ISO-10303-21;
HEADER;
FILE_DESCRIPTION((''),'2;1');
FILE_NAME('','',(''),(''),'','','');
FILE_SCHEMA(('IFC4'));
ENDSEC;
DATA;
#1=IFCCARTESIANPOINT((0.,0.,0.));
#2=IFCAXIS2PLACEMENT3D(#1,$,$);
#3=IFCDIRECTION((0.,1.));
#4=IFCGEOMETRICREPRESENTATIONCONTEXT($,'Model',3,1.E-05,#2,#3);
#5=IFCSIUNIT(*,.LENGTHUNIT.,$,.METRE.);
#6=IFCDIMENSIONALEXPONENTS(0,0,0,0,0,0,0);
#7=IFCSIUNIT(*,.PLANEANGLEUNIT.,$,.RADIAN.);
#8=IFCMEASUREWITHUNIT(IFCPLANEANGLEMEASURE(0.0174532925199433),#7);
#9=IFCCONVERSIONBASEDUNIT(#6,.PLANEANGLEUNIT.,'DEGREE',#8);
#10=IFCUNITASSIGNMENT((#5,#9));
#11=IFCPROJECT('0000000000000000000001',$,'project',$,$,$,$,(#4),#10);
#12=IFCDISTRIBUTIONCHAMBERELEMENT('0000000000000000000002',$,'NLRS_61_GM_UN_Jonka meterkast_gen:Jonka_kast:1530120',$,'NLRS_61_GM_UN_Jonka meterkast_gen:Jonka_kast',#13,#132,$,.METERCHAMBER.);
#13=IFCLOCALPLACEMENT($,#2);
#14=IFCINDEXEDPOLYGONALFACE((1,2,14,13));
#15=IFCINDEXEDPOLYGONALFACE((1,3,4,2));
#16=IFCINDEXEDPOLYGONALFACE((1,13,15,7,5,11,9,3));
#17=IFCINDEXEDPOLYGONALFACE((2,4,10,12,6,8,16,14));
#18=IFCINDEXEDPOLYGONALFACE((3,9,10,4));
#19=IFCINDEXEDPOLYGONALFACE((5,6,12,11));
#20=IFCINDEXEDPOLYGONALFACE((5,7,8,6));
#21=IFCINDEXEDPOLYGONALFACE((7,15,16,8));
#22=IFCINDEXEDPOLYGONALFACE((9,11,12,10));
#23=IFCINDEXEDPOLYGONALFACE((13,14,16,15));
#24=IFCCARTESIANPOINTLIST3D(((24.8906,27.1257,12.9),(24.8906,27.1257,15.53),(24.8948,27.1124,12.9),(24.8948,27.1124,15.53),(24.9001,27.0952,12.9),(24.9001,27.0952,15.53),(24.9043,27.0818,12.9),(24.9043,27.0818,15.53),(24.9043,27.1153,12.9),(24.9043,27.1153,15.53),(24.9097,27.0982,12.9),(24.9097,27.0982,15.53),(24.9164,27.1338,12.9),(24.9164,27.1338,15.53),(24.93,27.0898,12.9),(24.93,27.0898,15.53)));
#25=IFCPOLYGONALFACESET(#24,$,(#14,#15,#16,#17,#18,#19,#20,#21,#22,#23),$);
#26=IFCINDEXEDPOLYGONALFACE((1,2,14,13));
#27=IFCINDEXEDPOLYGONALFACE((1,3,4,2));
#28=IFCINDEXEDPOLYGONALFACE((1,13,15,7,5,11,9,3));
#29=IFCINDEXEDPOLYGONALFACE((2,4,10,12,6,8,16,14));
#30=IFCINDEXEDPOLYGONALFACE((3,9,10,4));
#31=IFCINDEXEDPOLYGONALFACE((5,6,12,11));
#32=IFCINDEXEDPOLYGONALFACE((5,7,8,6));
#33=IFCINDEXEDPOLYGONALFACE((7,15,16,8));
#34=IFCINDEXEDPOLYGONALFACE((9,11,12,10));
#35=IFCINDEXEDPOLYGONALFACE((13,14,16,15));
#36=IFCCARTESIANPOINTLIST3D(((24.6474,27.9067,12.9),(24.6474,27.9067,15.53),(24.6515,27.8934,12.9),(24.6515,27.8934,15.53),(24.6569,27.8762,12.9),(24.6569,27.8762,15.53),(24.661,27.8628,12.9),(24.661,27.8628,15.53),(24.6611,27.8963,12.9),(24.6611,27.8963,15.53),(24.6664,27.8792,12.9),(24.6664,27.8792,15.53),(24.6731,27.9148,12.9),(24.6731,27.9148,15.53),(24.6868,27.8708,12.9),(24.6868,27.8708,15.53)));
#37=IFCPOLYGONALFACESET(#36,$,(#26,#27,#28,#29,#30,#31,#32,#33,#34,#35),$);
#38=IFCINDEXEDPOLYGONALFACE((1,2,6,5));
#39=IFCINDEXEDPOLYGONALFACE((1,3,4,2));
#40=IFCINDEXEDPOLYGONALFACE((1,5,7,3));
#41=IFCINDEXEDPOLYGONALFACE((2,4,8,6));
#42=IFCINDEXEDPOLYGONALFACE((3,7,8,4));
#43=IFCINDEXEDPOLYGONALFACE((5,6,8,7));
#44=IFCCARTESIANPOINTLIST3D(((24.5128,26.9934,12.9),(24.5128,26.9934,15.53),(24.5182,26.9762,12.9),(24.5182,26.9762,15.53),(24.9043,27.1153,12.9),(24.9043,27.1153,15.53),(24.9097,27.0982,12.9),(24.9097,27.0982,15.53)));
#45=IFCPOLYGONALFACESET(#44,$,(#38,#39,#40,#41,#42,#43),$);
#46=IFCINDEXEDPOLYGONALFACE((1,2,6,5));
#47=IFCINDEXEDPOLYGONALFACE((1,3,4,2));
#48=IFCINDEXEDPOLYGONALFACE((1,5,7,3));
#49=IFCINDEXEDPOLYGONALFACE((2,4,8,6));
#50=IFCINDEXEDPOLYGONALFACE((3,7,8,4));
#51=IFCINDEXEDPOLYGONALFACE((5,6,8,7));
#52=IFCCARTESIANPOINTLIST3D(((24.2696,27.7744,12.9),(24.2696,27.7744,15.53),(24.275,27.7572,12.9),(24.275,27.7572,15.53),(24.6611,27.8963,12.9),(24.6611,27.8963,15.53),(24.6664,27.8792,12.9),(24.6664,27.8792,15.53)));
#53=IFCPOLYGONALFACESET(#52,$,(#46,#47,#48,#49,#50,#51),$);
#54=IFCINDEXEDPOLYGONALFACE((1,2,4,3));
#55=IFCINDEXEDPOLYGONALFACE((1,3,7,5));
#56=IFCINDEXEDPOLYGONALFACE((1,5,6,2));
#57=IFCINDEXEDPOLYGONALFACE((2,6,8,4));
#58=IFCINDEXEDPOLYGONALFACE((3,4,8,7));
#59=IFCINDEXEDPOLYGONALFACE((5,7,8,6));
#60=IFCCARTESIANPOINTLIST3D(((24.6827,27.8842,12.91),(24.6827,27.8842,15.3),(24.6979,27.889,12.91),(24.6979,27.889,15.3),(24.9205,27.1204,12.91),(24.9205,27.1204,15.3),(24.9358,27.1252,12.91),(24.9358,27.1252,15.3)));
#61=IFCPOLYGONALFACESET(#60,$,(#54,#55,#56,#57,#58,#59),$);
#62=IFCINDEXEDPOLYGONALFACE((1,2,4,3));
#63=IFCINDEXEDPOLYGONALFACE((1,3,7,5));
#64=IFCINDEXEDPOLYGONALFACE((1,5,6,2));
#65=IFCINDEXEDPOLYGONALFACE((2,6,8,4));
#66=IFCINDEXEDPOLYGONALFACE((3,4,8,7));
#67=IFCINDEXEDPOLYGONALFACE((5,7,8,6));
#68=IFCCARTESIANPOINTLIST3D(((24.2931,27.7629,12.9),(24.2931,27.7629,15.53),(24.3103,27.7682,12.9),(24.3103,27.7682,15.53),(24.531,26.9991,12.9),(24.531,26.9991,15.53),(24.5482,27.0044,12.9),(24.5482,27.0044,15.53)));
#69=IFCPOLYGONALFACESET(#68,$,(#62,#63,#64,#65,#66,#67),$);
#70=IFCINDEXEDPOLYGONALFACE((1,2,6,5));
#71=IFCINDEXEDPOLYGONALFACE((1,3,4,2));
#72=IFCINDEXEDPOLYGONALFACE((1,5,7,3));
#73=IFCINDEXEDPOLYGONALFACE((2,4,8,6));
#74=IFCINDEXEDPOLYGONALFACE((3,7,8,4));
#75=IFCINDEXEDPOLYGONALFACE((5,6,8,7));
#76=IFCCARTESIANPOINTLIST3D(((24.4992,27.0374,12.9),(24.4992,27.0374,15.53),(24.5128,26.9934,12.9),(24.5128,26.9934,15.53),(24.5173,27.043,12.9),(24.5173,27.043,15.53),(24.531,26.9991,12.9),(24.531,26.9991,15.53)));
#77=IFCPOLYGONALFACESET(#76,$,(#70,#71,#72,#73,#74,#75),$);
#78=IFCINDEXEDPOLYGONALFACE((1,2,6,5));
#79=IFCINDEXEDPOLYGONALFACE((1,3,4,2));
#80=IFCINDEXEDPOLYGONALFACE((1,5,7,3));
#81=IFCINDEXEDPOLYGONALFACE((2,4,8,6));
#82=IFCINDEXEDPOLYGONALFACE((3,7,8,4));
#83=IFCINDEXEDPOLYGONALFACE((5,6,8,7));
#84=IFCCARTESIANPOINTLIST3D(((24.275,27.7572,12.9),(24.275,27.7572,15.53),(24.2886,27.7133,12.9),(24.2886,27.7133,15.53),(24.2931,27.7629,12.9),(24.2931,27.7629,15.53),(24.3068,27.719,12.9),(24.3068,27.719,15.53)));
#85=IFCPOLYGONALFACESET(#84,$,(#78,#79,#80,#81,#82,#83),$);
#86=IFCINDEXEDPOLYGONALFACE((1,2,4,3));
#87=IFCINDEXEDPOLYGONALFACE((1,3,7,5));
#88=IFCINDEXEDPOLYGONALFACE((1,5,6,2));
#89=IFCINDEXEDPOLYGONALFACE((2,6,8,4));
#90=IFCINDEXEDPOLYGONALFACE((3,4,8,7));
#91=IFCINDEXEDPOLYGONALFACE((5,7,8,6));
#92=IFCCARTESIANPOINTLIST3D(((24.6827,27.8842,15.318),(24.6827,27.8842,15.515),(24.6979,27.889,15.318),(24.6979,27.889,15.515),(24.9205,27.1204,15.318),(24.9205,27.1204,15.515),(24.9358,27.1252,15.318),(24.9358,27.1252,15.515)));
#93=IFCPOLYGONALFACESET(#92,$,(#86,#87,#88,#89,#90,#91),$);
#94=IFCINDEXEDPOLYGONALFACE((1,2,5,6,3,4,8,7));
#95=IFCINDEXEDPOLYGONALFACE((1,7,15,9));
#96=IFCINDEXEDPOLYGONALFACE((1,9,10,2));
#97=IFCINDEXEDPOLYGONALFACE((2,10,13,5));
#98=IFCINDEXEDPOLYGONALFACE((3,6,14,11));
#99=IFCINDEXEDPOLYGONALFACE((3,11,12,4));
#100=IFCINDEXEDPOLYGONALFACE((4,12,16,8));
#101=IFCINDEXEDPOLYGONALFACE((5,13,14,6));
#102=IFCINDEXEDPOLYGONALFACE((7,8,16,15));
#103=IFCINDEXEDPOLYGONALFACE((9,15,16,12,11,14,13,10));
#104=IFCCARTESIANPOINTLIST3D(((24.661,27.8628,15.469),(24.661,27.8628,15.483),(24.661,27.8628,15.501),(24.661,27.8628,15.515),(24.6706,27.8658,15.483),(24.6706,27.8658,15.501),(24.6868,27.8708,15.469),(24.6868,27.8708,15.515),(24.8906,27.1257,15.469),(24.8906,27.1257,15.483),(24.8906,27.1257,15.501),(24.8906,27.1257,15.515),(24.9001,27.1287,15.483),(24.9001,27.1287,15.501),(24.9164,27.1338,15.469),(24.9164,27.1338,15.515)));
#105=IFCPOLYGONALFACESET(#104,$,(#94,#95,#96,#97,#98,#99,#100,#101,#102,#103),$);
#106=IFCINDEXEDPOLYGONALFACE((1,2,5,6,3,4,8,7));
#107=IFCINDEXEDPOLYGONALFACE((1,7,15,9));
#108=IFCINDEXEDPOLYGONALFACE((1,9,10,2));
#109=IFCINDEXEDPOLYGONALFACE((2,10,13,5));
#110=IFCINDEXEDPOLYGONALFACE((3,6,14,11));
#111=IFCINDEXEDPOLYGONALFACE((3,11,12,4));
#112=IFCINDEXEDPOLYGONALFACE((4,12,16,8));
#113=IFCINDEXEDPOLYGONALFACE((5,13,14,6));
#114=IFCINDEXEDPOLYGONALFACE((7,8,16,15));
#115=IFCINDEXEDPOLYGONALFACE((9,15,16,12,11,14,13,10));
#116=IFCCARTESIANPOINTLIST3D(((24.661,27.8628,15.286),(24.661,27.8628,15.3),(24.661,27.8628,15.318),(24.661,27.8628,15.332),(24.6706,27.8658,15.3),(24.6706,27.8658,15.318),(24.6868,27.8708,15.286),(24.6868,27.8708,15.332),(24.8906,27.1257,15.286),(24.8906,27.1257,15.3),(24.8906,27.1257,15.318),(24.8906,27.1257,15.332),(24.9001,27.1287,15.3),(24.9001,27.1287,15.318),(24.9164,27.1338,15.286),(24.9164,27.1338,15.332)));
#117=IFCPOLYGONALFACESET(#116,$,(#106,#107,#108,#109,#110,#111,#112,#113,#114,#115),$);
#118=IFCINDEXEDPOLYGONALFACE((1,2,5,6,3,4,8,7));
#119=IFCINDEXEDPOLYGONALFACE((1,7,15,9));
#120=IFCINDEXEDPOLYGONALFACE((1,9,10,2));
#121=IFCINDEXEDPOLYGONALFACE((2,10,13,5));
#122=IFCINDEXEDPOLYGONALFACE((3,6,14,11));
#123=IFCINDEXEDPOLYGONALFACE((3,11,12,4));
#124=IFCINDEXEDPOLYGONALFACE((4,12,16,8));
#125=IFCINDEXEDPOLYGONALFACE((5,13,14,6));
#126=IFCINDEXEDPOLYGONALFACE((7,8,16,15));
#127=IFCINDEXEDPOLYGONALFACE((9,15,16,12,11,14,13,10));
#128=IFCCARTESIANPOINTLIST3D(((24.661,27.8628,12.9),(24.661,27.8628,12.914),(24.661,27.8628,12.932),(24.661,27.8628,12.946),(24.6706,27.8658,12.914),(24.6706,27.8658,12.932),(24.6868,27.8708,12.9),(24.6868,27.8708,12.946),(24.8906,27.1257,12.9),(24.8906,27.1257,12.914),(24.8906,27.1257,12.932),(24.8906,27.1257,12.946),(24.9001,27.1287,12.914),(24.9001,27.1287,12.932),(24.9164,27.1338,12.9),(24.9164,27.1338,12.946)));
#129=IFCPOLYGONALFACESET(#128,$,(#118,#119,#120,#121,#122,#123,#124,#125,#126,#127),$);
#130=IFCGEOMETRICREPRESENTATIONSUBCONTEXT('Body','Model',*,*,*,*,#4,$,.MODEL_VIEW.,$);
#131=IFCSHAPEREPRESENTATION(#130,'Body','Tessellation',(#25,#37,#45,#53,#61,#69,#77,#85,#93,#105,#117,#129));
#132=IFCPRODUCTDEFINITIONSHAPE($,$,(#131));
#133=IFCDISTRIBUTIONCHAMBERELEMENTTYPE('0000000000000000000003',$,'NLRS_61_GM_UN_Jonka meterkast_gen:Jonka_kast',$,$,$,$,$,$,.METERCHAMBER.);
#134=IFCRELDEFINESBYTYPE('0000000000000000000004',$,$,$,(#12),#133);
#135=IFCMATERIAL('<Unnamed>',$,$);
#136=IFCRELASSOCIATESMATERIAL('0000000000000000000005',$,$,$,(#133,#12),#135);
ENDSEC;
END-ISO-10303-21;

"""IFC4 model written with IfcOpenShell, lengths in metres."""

from ifc_helpers import new_model, entity, si_unit, converted_unit, direction, frame, origin, place, context, subcontext, project, indexed_curve, outline, extrude, source, transform, mapped, material, type_object, type_shapes, element, save


model = new_model("IFC4")

# Units and contexts
model_context = context("Model", 3, precision=1e-05, world=origin(), true_north=direction((0.0, 1.0)))
body_context = subcontext(model_context, "Body", "Model", "MODEL_VIEW")
ifc_project = project(units=[si_unit("LENGTHUNIT", "METRE"), converted_unit("PLANEANGLEUNIT", "DEGREE", entity("IfcPlaneAngleMeasure", 0.0174532925199433), si_unit("PLANEANGLEUNIT", "RADIAN"), dimensions=[0, 0, 0, 0, 0, 0, 0])], contexts=[model_context])

# Distribution chamber element
ifc_material = material(Name="<Unnamed>")
distribution_chamber_element_type = type_object("IfcDistributionChamberElementType", Name="NLRS_61_GM_UN_Jonka meterkast_gen:Jonka_kast", PredefinedType="METERCHAMBER", material=ifc_material)
shared_shape_1 = source(origin(), body_context, "Body", "SweptSolid", [
    extrude(outline(indexed_curve([(-0.0093, -0.023), (0.0178, -0.023), (0.0178, 0.023), (-0.0093, 0.023), (-0.0093, 0.009), (0.0007, 0.009), (0.0007, -0.009), (-0.0093, -0.009), (-0.0093, -0.023)], self_intersect=False)), frame((-0.409, -0.4092, 0.0), z_axis=(0.0, 0.0, 1.0), x_axis=(0.0, -1.0, 0.0)), (0.0, 0.0, 1.0), 2.63),
    extrude(outline(indexed_curve([(-0.0093, -0.023), (0.0178, -0.023), (0.0178, 0.023), (-0.0093, 0.023), (-0.0093, 0.009), (0.0007, 0.009), (0.0007, -0.009), (-0.0093, -0.009), (-0.0093, -0.023)], self_intersect=False)), frame((0.409, -0.4092, 0.0), z_axis=(0.0, 0.0, 1.0), x_axis=(0.0, -1.0, 0.0)), (0.0, 0.0, 1.0), 2.63),
    extrude(outline(indexed_curve([(-0.205, -0.009), (0.205, -0.009), (0.205, 0.009), (-0.205, 0.009), (-0.205, -0.009)], self_intersect=False)), frame((-0.409, -0.205, 0.0), z_axis=(0.0, 0.0, 1.0), x_axis=(0.0, -1.0, 0.0)), (0.0, 0.0, 1.0), 2.63),
    extrude(outline(indexed_curve([(-0.205, -0.009), (0.205, -0.009), (0.205, 0.009), (-0.205, 0.009), (-0.205, -0.009)], self_intersect=False)), frame((0.409, -0.205, 0.0), z_axis=(0.0, 0.0, 1.0), x_axis=(0.0, -1.0, 0.0)), (0.0, 0.0, 1.0), 2.63),
    extrude(outline(indexed_curve([(-0.4, -0.008), (0.4, -0.008), (0.4, 0.008), (-0.4, 0.008), (-0.4, -0.008)], self_intersect=False)), frame((0.0, -0.435, 0.01), z_axis=(0.0, 0.0, 1.0), x_axis=(-1.0, 0.0, 0.0)), (0.0, 0.0, 1.0), 2.39),
    extrude(outline(indexed_curve([(-0.4, -0.009), (0.4, -0.009), (0.4, 0.009), (-0.4, 0.009), (-0.4, -0.009)], self_intersect=False)), frame((0.0, -0.028, 0.0), z_axis=(0.0, 0.0, 1.0), x_axis=(-1.0, 0.0, 0.0)), (0.0, 0.0, 1.0), 2.63),
    extrude(outline(indexed_curve([(-0.023, -0.0095), (0.023, -0.0095), (0.023, 0.0095), (-0.023, 0.0095), (-0.023, -0.0095)], self_intersect=False)), frame((-0.377, -0.0095, 0.0), z_axis=(0.0, 0.0, 1.0), x_axis=(-1.0, 0.0, 0.0)), (0.0, 0.0, 1.0), 2.63),
    extrude(outline(indexed_curve([(-0.023, -0.0095), (0.023, -0.0095), (0.023, 0.0095), (-0.023, 0.0095), (-0.023, -0.0095)], self_intersect=False)), frame((0.377, -0.0095, 0.0), z_axis=(0.0, 0.0, 1.0), x_axis=(-1.0, 0.0, 0.0)), (0.0, 0.0, 1.0), 2.63),
    extrude(outline(indexed_curve([(-0.4, -0.008), (0.4, -0.008), (0.4, 0.008), (-0.4, 0.008), (-0.4, -0.008)], self_intersect=False)), frame((0.0, -0.435, 2.418), z_axis=(0.0, 0.0, 1.0), x_axis=(-1.0, 0.0, 0.0)), (0.0, 0.0, 1.0), 0.197),
    extrude(outline(indexed_curve([(-0.023, -0.0178), (0.023, -0.0178), (0.023, 0.0093), (0.009, 0.0093), (0.009, -0.0007), (-0.009, -0.0007), (-0.009, 0.0093), (-0.023, 0.0093), (-0.023, -0.0178)], self_intersect=False)), frame((-0.386, -0.4092, 2.592), z_axis=(1.0, 0.0, 0.0), x_axis=(0.0, 0.0, -1.0)), (0.0, 0.0, 1.0), 0.772),
    extrude(outline(indexed_curve([(-0.023, -0.0178), (0.023, -0.0178), (0.023, 0.0093), (0.009, 0.0093), (0.009, -0.0007), (-0.009, -0.0007), (-0.009, 0.0093), (-0.023, 0.0093), (-0.023, -0.0178)], self_intersect=False)), frame((-0.386, -0.4092, 2.409), z_axis=(1.0, 0.0, 0.0), x_axis=(0.0, 0.0, -1.0)), (0.0, 0.0, 1.0), 0.772),
    extrude(outline(indexed_curve([(-0.023, -0.0178), (0.023, -0.0178), (0.023, 0.0093), (0.009, 0.0093), (0.009, -0.0007), (-0.009, -0.0007), (-0.009, 0.0093), (-0.023, 0.0093), (-0.023, -0.0178)], self_intersect=False)), frame((-0.386, -0.4092, 0.023), z_axis=(1.0, 0.0, 0.0), x_axis=(0.0, 0.0, -1.0)), (0.0, 0.0, 1.0), 0.772),
])
type_shapes(distribution_chamber_element_type, [shared_shape_1])
placement_1 = place(None, frame((13.1348, 11.9886, 0.0), z_axis=(0.0, 0.0, 1.0), x_axis=(0.954771, 0.297342, 0.0)))
placement_2 = place(placement_1, origin())
placement_3 = place(placement_2, frame((0.0, 0.0, 12.9)))
placement_4 = place(placement_3, origin())
distribution_chamber_element_1_placement = place(placement_4, frame((15.325, 11.343, 0.0), z_axis=(0.0, 0.0, 1.0), x_axis=(0.0, 1.0, 0.0)))
element("IfcDistributionChamberElement", 1, at=distribution_chamber_element_1_placement, type_object=distribution_chamber_element_type, material=ifc_material, Name="NLRS_61_GM_UN_Jonka meterkast_gen:Jonka_kast:1530120", ObjectType="NLRS_61_GM_UN_Jonka meterkast_gen:Jonka_kast", PredefinedType="METERCHAMBER", context=body_context, shape_type="MappedRepresentation", body=[
    mapped(shared_shape_1, transform((0.0, 0.0, 0.0), scale=1.0)),
])

save(model, "model.ifc")
